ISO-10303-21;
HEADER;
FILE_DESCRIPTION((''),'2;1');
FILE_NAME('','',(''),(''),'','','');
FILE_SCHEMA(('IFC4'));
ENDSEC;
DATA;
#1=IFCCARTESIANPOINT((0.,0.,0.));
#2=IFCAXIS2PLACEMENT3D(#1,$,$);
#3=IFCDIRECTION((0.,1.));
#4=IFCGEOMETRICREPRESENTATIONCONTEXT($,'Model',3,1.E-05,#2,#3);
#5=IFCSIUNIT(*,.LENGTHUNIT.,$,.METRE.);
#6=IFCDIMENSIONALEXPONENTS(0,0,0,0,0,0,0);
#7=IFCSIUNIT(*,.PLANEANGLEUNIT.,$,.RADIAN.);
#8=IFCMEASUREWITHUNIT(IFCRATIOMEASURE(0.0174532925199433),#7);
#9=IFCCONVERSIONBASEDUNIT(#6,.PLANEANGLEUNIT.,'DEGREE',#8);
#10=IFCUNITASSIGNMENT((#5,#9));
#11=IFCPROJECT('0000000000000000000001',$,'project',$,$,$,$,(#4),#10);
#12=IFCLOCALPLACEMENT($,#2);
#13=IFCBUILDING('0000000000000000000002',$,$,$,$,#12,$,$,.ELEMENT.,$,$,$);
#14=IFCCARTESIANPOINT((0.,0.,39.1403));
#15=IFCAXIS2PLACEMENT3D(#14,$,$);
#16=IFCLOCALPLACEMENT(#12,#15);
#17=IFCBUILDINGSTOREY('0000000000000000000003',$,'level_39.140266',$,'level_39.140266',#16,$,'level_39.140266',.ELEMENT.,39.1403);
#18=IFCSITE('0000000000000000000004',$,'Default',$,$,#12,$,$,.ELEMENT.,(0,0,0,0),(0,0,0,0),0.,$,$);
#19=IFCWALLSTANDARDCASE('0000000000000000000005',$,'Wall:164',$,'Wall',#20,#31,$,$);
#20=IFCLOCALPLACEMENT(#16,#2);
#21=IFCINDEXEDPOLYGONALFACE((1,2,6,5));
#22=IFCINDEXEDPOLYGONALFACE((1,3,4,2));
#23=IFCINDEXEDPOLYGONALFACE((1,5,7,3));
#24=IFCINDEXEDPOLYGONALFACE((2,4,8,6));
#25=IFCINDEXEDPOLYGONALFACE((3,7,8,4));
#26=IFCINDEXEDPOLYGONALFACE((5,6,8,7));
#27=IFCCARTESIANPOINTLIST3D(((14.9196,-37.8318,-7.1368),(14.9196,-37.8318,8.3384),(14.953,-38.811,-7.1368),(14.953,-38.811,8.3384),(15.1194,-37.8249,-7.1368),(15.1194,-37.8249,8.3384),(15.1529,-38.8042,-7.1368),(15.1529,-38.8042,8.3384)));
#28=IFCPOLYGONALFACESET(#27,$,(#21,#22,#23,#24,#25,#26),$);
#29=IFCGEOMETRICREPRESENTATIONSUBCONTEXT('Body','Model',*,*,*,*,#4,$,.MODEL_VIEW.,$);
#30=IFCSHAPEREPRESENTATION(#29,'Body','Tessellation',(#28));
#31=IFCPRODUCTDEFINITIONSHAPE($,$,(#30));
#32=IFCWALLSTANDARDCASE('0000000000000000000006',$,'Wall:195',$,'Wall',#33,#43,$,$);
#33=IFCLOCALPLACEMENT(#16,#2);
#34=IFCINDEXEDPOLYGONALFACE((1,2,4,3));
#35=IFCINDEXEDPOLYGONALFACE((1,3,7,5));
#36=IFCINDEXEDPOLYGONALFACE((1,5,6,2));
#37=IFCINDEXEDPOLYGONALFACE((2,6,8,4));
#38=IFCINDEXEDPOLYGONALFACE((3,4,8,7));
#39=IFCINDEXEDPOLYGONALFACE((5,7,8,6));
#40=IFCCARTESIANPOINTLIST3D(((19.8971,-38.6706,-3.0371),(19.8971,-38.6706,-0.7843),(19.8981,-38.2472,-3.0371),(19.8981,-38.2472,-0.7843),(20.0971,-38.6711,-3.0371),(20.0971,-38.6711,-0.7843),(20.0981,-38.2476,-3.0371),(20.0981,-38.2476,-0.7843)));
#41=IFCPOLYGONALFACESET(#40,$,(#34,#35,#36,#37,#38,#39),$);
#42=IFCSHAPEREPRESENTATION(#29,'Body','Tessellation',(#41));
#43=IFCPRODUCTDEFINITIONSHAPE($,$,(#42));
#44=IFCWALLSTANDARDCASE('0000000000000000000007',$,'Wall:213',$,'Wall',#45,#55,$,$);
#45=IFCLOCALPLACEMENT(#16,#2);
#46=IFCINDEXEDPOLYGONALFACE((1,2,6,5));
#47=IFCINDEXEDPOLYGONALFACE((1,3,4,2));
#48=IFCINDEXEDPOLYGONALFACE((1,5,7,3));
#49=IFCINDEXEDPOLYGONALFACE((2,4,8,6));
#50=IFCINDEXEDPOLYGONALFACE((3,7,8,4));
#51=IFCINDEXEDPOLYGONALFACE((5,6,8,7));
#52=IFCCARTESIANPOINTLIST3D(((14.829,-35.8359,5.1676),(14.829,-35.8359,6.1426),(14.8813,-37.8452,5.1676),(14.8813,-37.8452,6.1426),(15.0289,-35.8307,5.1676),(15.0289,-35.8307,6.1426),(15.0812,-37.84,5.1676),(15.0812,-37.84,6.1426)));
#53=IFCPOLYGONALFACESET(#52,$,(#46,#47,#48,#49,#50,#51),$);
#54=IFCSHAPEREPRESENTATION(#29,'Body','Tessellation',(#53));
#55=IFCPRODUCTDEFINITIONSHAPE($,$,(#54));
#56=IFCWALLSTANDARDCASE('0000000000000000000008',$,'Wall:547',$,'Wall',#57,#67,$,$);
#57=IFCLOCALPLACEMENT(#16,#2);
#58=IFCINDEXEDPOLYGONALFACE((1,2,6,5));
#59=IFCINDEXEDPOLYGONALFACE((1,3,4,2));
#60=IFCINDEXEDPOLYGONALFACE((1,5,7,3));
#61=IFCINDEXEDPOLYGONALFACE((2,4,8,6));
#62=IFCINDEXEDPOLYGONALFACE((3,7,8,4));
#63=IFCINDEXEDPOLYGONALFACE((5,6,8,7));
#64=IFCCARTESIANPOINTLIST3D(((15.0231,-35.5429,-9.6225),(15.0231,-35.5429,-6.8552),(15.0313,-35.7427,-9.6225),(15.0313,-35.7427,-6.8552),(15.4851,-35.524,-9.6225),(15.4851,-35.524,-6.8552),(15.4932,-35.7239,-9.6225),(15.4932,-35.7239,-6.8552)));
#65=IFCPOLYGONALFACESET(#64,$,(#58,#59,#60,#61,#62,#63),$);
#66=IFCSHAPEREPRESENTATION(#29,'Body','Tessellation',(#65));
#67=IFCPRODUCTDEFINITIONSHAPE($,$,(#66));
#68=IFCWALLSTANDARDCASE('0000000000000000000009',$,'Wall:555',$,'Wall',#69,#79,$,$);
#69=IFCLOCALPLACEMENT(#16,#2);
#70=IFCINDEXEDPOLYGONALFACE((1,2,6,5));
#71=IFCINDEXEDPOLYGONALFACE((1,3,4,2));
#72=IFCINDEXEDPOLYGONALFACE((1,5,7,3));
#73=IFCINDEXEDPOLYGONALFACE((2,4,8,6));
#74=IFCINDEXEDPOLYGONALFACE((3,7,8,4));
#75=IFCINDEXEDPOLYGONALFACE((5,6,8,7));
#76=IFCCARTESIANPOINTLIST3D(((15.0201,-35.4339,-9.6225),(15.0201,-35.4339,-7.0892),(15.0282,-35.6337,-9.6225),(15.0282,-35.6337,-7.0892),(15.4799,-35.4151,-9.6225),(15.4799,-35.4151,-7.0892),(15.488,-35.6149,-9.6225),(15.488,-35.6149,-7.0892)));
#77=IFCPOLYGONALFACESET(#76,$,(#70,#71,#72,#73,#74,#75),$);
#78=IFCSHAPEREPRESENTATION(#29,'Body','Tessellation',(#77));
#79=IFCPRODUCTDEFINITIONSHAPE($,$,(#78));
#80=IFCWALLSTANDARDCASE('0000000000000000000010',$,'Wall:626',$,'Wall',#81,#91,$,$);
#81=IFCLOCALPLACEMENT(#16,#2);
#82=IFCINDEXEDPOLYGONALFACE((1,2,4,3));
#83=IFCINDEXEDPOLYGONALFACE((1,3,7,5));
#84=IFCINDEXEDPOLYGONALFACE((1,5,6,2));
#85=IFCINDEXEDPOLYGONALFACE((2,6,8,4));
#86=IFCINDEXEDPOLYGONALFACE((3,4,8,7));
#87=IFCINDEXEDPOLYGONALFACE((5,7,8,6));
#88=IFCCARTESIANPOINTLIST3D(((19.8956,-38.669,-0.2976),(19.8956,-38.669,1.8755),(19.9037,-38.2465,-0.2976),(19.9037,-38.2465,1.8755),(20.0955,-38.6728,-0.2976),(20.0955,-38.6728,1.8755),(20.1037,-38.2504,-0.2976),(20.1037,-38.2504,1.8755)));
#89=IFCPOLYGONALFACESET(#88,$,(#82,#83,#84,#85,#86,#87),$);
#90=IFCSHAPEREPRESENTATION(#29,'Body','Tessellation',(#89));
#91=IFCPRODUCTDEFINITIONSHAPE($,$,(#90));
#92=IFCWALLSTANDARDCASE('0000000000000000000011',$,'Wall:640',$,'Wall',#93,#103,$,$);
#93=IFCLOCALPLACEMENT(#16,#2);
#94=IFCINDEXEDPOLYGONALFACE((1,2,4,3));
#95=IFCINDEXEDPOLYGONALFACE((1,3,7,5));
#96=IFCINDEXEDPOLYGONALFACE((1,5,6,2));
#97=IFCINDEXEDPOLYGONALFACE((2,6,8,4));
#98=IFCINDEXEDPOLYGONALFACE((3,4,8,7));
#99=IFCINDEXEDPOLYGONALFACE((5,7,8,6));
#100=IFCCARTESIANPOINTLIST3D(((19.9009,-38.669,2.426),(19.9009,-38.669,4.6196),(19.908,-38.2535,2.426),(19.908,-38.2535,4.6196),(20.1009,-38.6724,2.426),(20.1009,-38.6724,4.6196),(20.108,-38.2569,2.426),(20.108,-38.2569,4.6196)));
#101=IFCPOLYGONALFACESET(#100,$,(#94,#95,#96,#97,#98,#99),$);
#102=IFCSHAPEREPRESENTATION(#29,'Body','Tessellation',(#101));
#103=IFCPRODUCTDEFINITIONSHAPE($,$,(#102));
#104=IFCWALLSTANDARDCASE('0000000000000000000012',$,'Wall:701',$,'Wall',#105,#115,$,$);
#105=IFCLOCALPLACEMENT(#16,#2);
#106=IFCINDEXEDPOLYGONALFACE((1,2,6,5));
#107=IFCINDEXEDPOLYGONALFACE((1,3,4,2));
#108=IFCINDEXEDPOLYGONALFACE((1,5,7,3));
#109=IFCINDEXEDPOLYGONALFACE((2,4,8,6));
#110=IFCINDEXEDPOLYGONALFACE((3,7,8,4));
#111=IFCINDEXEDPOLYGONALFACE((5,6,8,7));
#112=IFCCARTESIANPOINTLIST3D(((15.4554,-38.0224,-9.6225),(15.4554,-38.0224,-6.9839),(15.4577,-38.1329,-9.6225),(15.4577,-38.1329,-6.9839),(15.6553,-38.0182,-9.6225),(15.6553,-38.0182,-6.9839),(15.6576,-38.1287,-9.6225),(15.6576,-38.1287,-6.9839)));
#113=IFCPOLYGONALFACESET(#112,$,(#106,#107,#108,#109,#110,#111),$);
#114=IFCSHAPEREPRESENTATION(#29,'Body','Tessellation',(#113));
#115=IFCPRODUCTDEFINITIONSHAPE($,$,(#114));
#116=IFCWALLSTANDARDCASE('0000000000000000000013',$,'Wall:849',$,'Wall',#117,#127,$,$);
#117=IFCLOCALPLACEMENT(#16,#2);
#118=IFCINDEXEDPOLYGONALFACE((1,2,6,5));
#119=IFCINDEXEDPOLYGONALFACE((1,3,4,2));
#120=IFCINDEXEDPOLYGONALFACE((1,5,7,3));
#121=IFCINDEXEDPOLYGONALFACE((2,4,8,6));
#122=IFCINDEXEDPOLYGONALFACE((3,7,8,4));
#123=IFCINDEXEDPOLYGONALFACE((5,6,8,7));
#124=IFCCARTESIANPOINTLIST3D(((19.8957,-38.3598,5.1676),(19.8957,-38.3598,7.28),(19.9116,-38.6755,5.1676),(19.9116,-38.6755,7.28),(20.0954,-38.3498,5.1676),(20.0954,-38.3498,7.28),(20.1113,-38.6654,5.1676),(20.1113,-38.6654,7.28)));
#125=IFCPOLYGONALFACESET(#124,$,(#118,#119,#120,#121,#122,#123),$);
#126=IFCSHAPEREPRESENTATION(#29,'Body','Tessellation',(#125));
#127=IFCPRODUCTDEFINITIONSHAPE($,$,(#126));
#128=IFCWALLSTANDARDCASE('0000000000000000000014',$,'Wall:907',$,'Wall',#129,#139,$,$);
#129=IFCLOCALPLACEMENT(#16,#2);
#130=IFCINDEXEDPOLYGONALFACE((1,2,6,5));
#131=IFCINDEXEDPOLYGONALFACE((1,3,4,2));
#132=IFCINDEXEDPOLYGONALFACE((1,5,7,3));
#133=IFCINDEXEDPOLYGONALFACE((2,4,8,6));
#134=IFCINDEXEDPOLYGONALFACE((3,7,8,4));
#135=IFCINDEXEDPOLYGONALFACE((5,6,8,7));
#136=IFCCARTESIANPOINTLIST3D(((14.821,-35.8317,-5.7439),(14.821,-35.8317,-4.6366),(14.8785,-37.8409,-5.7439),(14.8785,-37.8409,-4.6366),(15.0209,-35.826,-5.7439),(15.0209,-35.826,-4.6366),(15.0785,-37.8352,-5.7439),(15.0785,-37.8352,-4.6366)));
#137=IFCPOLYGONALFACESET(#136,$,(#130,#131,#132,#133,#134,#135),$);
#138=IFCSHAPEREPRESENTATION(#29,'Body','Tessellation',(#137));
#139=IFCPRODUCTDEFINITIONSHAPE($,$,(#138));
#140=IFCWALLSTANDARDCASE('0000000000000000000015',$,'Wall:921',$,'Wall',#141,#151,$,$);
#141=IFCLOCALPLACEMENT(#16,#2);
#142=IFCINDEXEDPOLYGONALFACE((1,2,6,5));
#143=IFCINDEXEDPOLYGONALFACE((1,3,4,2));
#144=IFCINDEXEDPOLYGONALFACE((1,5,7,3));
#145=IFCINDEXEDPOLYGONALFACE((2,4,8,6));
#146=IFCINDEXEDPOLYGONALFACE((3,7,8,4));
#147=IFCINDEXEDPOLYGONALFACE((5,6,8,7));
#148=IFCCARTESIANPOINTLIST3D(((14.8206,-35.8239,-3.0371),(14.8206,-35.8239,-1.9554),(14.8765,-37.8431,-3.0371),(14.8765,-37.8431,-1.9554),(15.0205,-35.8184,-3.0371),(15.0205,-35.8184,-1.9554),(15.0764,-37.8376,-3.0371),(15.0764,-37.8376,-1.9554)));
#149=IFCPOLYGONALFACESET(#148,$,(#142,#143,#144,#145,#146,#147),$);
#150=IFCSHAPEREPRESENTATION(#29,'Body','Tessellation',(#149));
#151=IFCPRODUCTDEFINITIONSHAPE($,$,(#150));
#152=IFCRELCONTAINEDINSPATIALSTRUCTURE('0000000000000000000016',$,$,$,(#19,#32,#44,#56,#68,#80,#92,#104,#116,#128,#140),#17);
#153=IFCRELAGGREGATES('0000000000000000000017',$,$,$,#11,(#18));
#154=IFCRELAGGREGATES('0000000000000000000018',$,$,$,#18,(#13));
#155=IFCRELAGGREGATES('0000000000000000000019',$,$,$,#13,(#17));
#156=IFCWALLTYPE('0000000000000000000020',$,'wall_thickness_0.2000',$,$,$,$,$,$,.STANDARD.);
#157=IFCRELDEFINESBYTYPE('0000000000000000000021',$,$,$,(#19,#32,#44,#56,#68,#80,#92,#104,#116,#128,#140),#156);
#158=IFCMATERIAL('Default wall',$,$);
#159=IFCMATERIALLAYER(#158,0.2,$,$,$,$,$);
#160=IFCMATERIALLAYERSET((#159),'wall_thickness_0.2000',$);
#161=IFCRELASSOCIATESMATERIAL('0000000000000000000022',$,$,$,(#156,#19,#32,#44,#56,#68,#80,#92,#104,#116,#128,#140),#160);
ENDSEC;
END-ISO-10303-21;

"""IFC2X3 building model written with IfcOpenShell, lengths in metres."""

from ifc_helpers import new_model, entity, si_unit, converted_unit, direction, frame, origin, place, context, subcontext, project, spatial, polyline, outline, extrude, material, layer, layer_set, layer_usage, type_object, element, save


model = new_model("IFC2X3")

# Units and contexts
model_context = context("Model", 3, precision=1e-05, world=origin(), true_north=direction((0.0, 1.0)))
body_context = subcontext(model_context, "Body", "Model", "MODEL_VIEW")
ifc_project = project(units=[si_unit("LENGTHUNIT", "METRE"), converted_unit("PLANEANGLEUNIT", "DEGREE", entity("IfcRatioMeasure", 0.0174532925199433), si_unit("PLANEANGLEUNIT", "RADIAN"), dimensions=[0, 0, 0, 0, 0, 0, 0])], contexts=[model_context])

# Site, building, storey
placement_1 = place(None, origin())
site = spatial("IfcSite", under=ifc_project, at=placement_1, Name="Default", CompositionType="ELEMENT", RefLatitude=(0, 0, 0, 0), RefLongitude=(0, 0, 0, 0), RefElevation=0.0)
building = spatial("IfcBuilding", under=site, at=placement_1, CompositionType="ELEMENT")
storey_placement = place(placement_1, frame((0.0, 0.0, 39.1403)))
storey = spatial("IfcBuildingStorey", under=building, at=storey_placement, Name="level_39.140266", ObjectType="level_39.140266", LongName="level_39.140266", CompositionType="ELEMENT", Elevation=39.1403)

# Walls
ifc_material_1 = material(Name="Default wall")
ifc_layer = layer(ifc_material_1, 0.2)
ifc_layer_set = layer_set([ifc_layer], Name="wall_thickness_0.2000")
ifc_layer_usage = layer_usage(ifc_layer_set, "AXIS2", "POSITIVE", -0.1)
wall_type = type_object("IfcWallType", Name="wall_thickness_0.2000", PredefinedType="STANDARD", material=ifc_layer_set)
placement_2 = place(placement_1, frame((0.0, 0.0, 32.0035)))
wall_1_placement = place(placement_2, frame((15.0529, -38.8076, 0.0), z_axis=(0.0, 0.0, 1.0), x_axis=(-0.034109, 0.999418, 0.0)))
element("IfcWallStandardCase", 1, at=wall_1_placement, inside=storey, type_object=wall_type, material=ifc_layer_usage, Name="Wall:164", ObjectType="Wall", context=body_context, shape_type="SweptSolid", body=[
    extrude(outline(polyline([(0.9798, -0.1), (0.9798, 0.1), (0.0, 0.1), (0.0, -0.1), (0.9798, -0.1)])), origin(), (0.0, 0.0, 1.0), 15.4752),
])
placement_3 = place(placement_1, frame((0.0, 0.0, 36.1032)))
wall_2_placement = place(placement_3, frame((19.9971, -38.6708, 0.0), z_axis=(0.0, 0.0, 1.0), x_axis=(0.002279, 0.999997, 0.0)))
element("IfcWallStandardCase", 2, at=wall_2_placement, inside=storey, type_object=wall_type, material=ifc_layer_usage, Name="Wall:195", ObjectType="Wall", context=body_context, shape_type="SweptSolid", body=[
    extrude(outline(polyline([(0.4234, -0.1), (0.4234, 0.1), (0.0, 0.1), (0.0, -0.1), (0.4234, -0.1)])), origin(), (0.0, 0.0, 1.0), 2.2528),
])
placement_4 = place(placement_1, frame((0.0, 0.0, 44.3079)))
wall_3_placement = place(placement_4, frame((14.9812, -37.8426, 0.0), z_axis=(0.0, 0.0, 1.0), x_axis=(-0.026032, 0.999661, 0.0)))
element("IfcWallStandardCase", 3, at=wall_3_placement, inside=storey, type_object=wall_type, material=ifc_layer_usage, Name="Wall:213", ObjectType="Wall", context=body_context, shape_type="SweptSolid", body=[
    extrude(outline(polyline([(2.01, -0.1), (2.01, 0.1), (0.0, 0.1), (0.0, -0.1), (2.01, -0.1)])), origin(), (0.0, 0.0, 1.0), 0.975),
])
placement_5 = place(placement_1, frame((0.0, 0.0, 29.5178)))
wall_4_placement = place(placement_5, frame((15.4891, -35.6239, 0.0), z_axis=(0.0, 0.0, 1.0), x_axis=(-0.999171, -0.040711, 0.0)))
element("IfcWallStandardCase", 4, at=wall_4_placement, inside=storey, type_object=wall_type, material=ifc_layer_usage, Name="Wall:547", ObjectType="Wall", context=body_context, shape_type="SweptSolid", body=[
    extrude(outline(polyline([(0.4623, -0.1), (0.4623, 0.1), (0.0, 0.1), (0.0, -0.1), (0.4623, -0.1)])), origin(), (0.0, 0.0, 1.0), 2.7673),
])
placement_6 = place(placement_1, frame((0.0, 0.0, 29.5178)))
wall_5_placement = place(placement_6, frame((15.484, -35.515, 0.0), z_axis=(0.0, 0.0, 1.0), x_axis=(-0.999168, -0.040785, 0.0)))
element("IfcWallStandardCase", 5, at=wall_5_placement, inside=storey, type_object=wall_type, material=ifc_layer_usage, Name="Wall:555", ObjectType="Wall", context=body_context, shape_type="SweptSolid", body=[
    extrude(outline(polyline([(0.4602, -0.1), (0.4602, 0.1), (0.0, 0.1), (0.0, -0.1), (0.4602, -0.1)])), origin(), (0.0, 0.0, 1.0), 2.5333),
])
placement_7 = place(placement_1, frame((0.0, 0.0, 38.8427)))
wall_6_placement = place(placement_7, frame((20.0037, -38.2484, 0.0), z_axis=(0.0, 0.0, 1.0), x_axis=(-0.019357, -0.999813, 0.0)))
element("IfcWallStandardCase", 6, at=wall_6_placement, inside=storey, type_object=wall_type, material=ifc_layer_usage, Name="Wall:626", ObjectType="Wall", context=body_context, shape_type="SweptSolid", body=[
    extrude(outline(polyline([(0.4225, -0.1), (0.4225, 0.1), (0.0, 0.1), (0.0, -0.1), (0.4225, -0.1)])), origin(), (0.0, 0.0, 1.0), 2.1731),
])
placement_8 = place(placement_1, frame((0.0, 0.0, 41.5663)))
wall_7_placement = place(placement_8, frame((20.0009, -38.6707, 0.0), z_axis=(0.0, 0.0, 1.0), x_axis=(0.017095, 0.999854, 0.0)))
element("IfcWallStandardCase", 7, at=wall_7_placement, inside=storey, type_object=wall_type, material=ifc_layer_usage, Name="Wall:640", ObjectType="Wall", context=body_context, shape_type="SweptSolid", body=[
    extrude(outline(polyline([(0.4156, -0.1), (0.4156, 0.1), (0.0, 0.1), (0.0, -0.1), (0.4156, -0.1)])), origin(), (0.0, 0.0, 1.0), 2.1935),
])
placement_9 = place(placement_1, frame((0.0, 0.0, 29.5178)))
wall_8_placement = place(placement_9, frame((15.5554, -38.0203, 0.0), z_axis=(0.0, 0.0, 1.0), x_axis=(0.020791, -0.999784, 0.0)))
element("IfcWallStandardCase", 8, at=wall_8_placement, inside=storey, type_object=wall_type, material=ifc_layer_usage, Name="Wall:701", ObjectType="Wall", context=body_context, shape_type="SweptSolid", body=[
    extrude(outline(polyline([(0.1105, -0.1), (0.1105, 0.1), (0.0, 0.1), (0.0, -0.1), (0.1105, -0.1)])), origin(), (0.0, 0.0, 1.0), 2.6386),
])
placement_10 = place(placement_1, frame((0.0, 0.0, 44.3079)))
wall_9_placement = place(placement_10, frame((20.0115, -38.6704, 0.0), z_axis=(0.0, 0.0, 1.0), x_axis=(-0.05026, 0.998736, 0.0)))
element("IfcWallStandardCase", 9, at=wall_9_placement, inside=storey, type_object=wall_type, material=ifc_layer_usage, Name="Wall:849", ObjectType="Wall", context=body_context, shape_type="SweptSolid", body=[
    extrude(outline(polyline([(0.316, -0.1), (0.316, 0.1), (0.0, 0.1), (0.0, -0.1), (0.316, -0.1)])), origin(), (0.0, 0.0, 1.0), 2.1124),
])
placement_11 = place(placement_1, frame((0.0, 0.0, 33.3964)))
wall_10_placement = place(placement_11, frame((14.9785, -37.838, 0.0), z_axis=(0.0, 0.0, 1.0), x_axis=(-0.028636, 0.99959, 0.0)))
element("IfcWallStandardCase", 10, at=wall_10_placement, inside=storey, type_object=wall_type, material=ifc_layer_usage, Name="Wall:907", ObjectType="Wall", context=body_context, shape_type="SweptSolid", body=[
    extrude(outline(polyline([(2.01, -0.1), (2.01, 0.1), (0.0, 0.1), (0.0, -0.1), (2.01, -0.1)])), origin(), (0.0, 0.0, 1.0), 1.1073),
])
placement_12 = place(placement_1, frame((0.0, 0.0, 36.1032)))
wall_11_placement = place(placement_12, frame((14.9765, -37.8404, 0.0), z_axis=(0.0, 0.0, 1.0), x_axis=(-0.027704, 0.999616, 0.0)))
element("IfcWallStandardCase", 11, at=wall_11_placement, inside=storey, type_object=wall_type, material=ifc_layer_usage, Name="Wall:921", ObjectType="Wall", context=body_context, shape_type="SweptSolid", body=[
    extrude(outline(polyline([(2.02, -0.1), (2.02, 0.1), (0.0, 0.1), (0.0, -0.1), (2.02, -0.1)])), origin(), (0.0, 0.0, 1.0), 1.0817),
])

save(model, "model.ifc")
